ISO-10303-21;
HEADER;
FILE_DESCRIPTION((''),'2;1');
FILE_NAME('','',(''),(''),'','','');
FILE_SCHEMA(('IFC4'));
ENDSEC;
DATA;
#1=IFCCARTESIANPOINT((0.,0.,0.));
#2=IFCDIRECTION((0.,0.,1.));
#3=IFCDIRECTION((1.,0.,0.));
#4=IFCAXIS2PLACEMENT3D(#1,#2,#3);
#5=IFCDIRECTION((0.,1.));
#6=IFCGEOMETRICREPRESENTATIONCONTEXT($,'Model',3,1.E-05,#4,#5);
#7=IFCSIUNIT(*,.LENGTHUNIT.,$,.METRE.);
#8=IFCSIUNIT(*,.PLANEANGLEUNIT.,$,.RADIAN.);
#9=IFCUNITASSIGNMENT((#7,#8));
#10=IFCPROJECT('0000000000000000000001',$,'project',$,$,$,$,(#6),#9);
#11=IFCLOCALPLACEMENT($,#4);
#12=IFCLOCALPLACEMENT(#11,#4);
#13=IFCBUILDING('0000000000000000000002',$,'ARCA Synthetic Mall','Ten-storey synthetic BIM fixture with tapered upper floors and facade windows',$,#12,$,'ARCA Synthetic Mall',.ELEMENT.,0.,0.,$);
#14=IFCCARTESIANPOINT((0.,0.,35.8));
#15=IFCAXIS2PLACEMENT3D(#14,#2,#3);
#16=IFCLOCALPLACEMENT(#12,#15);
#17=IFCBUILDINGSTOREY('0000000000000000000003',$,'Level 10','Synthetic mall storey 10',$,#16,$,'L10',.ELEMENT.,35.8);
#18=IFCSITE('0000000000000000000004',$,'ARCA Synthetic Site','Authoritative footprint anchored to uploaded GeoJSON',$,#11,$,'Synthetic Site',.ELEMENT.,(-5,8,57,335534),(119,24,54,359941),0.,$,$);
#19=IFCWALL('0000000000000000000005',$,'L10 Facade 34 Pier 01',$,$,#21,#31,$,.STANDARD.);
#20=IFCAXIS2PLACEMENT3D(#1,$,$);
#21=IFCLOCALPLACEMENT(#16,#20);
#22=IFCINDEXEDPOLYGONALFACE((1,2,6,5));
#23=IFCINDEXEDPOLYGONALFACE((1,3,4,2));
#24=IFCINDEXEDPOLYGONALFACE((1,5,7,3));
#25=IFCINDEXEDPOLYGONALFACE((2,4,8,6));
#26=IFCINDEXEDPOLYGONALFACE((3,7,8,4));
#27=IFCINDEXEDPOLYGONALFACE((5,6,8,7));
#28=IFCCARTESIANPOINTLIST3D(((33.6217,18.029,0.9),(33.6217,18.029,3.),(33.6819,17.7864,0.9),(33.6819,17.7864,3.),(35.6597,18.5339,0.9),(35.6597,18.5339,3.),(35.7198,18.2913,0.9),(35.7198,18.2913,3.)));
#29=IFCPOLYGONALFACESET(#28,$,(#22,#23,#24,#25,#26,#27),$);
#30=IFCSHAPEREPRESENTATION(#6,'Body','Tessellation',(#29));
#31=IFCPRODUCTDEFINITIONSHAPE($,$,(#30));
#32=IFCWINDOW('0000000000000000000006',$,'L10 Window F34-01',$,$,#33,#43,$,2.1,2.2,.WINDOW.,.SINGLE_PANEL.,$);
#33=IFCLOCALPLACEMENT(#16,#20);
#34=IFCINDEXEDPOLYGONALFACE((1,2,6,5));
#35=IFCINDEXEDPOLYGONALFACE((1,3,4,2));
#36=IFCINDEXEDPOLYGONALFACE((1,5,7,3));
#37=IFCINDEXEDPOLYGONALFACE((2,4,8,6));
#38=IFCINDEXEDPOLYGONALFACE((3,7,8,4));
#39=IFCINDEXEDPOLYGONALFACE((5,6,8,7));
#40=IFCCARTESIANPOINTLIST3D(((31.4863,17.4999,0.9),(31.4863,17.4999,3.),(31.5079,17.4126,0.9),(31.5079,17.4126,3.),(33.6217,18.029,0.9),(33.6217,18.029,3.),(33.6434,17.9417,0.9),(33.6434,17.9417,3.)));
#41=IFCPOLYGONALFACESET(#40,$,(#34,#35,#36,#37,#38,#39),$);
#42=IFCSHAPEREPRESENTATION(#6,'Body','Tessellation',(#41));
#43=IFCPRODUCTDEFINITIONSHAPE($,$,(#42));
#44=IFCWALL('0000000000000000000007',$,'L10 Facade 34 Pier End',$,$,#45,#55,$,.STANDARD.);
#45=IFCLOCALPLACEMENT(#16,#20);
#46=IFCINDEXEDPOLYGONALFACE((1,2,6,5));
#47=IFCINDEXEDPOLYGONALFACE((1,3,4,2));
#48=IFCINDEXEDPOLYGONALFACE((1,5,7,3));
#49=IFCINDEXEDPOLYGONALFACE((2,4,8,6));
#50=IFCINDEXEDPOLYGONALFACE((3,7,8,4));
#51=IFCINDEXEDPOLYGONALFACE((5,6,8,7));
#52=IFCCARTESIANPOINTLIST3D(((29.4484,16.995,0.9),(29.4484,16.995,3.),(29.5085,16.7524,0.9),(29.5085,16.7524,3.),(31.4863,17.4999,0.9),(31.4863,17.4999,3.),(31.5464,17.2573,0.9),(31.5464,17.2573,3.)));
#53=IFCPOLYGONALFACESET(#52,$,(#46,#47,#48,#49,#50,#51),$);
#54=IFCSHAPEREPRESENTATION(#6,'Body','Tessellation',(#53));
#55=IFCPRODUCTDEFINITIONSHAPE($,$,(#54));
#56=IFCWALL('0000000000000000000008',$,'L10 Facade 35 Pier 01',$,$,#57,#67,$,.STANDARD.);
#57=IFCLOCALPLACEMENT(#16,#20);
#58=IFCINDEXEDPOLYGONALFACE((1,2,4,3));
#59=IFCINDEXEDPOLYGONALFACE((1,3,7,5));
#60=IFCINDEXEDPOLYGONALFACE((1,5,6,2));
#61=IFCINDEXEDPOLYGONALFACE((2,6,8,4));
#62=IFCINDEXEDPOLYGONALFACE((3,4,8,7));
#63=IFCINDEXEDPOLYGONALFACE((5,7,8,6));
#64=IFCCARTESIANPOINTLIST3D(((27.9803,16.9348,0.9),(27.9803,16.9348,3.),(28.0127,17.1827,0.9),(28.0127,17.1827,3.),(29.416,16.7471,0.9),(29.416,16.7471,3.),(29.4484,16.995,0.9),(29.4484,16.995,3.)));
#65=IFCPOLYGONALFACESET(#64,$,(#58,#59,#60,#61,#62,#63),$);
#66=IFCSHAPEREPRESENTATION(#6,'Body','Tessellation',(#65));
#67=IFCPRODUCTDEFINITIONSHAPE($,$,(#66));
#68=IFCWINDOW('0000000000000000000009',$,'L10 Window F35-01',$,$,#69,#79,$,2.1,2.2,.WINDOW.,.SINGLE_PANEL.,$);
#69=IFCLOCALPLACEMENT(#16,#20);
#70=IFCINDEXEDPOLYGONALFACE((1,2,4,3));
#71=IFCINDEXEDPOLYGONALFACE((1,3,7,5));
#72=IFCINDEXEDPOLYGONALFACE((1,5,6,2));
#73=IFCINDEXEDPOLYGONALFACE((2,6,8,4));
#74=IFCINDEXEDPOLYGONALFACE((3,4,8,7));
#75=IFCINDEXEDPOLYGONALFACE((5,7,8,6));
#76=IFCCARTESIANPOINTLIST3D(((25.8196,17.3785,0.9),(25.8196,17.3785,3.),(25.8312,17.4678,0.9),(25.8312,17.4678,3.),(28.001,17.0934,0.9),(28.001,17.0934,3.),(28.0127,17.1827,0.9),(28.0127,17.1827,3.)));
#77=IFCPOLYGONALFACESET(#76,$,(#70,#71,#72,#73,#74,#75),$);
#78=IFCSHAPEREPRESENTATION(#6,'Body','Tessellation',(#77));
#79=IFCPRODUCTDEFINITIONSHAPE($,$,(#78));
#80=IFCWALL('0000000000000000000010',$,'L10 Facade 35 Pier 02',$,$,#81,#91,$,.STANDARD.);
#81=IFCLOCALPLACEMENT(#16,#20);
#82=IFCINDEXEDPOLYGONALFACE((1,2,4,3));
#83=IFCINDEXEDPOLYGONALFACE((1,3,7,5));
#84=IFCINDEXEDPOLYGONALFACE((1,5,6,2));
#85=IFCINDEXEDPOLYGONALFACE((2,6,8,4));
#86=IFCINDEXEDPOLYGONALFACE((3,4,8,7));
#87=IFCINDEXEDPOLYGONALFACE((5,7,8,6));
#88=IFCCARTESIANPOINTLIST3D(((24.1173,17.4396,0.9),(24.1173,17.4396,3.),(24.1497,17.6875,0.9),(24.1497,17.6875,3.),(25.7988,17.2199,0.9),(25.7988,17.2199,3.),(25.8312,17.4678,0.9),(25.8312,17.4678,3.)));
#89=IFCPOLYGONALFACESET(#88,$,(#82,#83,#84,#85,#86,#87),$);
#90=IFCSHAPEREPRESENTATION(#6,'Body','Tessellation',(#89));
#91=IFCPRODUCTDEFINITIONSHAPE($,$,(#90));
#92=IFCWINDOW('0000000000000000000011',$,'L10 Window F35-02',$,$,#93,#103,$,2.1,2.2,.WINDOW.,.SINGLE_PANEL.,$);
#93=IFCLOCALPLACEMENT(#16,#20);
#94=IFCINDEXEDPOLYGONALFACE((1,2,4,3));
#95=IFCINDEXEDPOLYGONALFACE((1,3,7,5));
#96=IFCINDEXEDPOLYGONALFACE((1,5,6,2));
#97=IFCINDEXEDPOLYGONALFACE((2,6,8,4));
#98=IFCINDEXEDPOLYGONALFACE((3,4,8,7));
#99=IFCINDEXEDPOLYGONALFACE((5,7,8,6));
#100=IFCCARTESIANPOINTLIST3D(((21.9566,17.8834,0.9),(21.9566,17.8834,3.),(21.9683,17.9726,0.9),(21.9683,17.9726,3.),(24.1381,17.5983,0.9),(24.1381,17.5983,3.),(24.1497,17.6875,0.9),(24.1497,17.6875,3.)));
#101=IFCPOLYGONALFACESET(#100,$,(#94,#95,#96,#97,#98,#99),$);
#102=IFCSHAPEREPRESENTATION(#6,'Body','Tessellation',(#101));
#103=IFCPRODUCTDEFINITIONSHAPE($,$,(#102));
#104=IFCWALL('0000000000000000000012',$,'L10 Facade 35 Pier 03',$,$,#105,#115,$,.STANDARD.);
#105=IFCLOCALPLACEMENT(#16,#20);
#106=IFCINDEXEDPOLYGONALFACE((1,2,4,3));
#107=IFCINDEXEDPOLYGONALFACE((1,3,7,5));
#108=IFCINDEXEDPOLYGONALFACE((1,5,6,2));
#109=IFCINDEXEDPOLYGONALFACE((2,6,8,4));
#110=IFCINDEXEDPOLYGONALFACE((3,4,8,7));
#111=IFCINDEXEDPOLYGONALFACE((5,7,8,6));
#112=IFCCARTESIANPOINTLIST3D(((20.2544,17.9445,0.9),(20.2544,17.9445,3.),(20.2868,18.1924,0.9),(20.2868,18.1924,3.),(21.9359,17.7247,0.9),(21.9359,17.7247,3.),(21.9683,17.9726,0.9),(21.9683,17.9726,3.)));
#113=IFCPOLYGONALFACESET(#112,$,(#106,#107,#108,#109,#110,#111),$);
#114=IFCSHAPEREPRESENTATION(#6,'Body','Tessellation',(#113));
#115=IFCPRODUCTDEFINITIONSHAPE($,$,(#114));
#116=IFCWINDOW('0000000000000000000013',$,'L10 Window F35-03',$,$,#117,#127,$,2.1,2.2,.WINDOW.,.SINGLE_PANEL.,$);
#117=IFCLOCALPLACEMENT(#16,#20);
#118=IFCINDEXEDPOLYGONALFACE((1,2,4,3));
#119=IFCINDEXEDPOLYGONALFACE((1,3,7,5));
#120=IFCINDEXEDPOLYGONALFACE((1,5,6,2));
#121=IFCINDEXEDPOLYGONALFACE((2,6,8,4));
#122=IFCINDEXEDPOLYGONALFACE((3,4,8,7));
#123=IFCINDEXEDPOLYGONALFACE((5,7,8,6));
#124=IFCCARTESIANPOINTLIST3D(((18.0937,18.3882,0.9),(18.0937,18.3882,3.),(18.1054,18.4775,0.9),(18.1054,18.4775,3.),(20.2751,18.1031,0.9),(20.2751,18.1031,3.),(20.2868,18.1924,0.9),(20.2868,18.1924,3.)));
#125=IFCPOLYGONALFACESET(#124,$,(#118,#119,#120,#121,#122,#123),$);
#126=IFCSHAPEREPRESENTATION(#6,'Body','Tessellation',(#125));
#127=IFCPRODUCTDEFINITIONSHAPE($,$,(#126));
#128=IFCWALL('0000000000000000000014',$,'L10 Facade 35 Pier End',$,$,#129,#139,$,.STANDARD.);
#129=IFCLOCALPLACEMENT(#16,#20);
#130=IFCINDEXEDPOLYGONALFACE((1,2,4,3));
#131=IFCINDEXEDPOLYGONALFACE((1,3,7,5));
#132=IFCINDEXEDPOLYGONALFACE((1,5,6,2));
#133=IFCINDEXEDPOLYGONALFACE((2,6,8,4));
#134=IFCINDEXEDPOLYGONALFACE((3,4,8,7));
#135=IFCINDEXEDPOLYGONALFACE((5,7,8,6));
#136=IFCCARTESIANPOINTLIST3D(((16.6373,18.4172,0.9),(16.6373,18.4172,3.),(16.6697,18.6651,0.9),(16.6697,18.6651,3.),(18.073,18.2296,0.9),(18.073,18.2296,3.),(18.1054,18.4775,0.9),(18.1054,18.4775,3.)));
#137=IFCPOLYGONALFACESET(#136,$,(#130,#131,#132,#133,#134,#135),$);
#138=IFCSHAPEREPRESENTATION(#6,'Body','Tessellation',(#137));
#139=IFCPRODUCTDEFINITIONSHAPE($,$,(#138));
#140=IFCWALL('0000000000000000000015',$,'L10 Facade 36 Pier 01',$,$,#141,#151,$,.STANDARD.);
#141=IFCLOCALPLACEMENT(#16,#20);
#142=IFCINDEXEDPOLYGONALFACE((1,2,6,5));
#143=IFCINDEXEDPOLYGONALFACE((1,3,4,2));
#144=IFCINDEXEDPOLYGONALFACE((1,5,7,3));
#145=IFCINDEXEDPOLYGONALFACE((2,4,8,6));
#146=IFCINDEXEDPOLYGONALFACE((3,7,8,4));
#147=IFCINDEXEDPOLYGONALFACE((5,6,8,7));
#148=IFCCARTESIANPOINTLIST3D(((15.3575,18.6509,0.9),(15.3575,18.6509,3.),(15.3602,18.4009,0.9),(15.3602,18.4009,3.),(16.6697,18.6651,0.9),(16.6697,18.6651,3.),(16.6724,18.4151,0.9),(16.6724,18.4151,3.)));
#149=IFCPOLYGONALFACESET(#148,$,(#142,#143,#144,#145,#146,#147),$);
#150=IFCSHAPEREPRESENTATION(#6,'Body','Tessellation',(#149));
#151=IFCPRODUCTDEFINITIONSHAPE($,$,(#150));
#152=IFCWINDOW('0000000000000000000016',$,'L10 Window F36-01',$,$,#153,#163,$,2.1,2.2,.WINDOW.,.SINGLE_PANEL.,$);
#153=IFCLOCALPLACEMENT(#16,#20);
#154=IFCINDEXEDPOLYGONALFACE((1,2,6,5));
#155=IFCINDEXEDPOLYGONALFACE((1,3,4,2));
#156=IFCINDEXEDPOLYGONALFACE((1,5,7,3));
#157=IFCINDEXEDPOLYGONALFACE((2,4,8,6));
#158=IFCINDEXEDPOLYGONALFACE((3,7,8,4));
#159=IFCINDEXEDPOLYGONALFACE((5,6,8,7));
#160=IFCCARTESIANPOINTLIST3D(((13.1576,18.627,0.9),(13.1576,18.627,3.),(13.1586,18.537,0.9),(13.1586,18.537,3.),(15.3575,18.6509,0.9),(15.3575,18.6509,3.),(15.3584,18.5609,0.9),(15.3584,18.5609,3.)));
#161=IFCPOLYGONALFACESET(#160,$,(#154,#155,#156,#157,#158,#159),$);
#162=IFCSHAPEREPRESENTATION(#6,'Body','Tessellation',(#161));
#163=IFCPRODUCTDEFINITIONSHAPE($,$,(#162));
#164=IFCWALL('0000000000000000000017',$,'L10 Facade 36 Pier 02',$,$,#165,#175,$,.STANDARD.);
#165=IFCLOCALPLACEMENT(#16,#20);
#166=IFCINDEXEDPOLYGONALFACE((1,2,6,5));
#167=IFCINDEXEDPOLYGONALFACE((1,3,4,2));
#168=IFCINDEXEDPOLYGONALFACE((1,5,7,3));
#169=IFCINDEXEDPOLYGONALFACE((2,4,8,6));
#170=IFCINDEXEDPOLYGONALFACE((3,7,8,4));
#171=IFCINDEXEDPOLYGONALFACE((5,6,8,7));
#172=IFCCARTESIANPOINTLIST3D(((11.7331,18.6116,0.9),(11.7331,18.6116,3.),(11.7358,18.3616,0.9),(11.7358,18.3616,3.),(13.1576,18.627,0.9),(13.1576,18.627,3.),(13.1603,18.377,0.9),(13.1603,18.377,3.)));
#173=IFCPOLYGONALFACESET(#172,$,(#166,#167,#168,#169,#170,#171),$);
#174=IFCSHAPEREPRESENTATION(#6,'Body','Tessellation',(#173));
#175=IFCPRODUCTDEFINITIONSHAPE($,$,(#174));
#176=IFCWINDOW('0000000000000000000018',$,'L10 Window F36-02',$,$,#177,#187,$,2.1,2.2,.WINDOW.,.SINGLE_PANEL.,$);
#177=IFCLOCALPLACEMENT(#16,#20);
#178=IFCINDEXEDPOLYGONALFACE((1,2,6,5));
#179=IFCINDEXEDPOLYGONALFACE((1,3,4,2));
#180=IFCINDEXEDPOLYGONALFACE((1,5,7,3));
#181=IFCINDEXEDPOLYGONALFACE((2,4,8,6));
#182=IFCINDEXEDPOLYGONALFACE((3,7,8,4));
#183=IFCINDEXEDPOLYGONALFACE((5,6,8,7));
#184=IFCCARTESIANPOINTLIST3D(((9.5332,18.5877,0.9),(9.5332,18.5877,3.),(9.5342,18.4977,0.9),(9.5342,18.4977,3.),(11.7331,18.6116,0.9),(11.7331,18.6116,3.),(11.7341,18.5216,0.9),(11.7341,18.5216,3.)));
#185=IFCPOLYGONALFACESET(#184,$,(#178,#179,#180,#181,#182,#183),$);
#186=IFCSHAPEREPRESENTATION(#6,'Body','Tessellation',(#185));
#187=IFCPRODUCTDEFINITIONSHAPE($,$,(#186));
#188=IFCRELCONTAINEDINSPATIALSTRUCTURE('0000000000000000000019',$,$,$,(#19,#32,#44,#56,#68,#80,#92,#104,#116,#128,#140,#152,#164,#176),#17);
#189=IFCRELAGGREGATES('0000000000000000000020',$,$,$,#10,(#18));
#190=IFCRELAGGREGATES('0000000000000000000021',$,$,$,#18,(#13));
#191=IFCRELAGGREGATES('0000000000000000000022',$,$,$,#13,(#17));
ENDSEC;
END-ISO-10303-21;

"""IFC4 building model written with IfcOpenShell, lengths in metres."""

from ifc_helpers import new_model, si_unit, direction, frame, origin_with_axes, place, context, project, spatial, polyline, outline, extrude, element, save


model = new_model("IFC4")

# Units and contexts
model_context = context("Model", 3, precision=1e-05, world=origin_with_axes(), true_north=direction((0.0, 1.0)))
ifc_project = project(units=[si_unit("LENGTHUNIT", "METRE"), si_unit("PLANEANGLEUNIT", "RADIAN")], contexts=[model_context])

# Site, building, storey
site_placement = place(None, origin_with_axes())
site = spatial("IfcSite", under=ifc_project, at=site_placement, Name="ARCA Synthetic Site", Description="Authoritative footprint anchored to uploaded GeoJSON", LongName="Synthetic Site", CompositionType="ELEMENT", RefLatitude=(-5, 8, 57, 335534), RefLongitude=(119, 24, 54, 359941), RefElevation=0.0)
building_placement = place(site_placement, origin_with_axes())
building = spatial("IfcBuilding", under=site, at=building_placement, Name="ARCA Synthetic Mall", Description="Ten-storey synthetic BIM fixture with tapered upper floors and facade windows", LongName="ARCA Synthetic Mall", CompositionType="ELEMENT", ElevationOfRefHeight=0.0, ElevationOfTerrain=0.0)
storey_placement = place(building_placement, frame((0.0, 0.0, 35.8), z_axis=(0.0, 0.0, 1.0), x_axis=(1.0, 0.0, 0.0)))
storey = spatial("IfcBuildingStorey", under=building, at=storey_placement, Name="Level 10", Description="Synthetic mall storey 10", LongName="L10", CompositionType="ELEMENT", Elevation=35.8)

# Wall
wall_1_placement = place(storey_placement, frame((0.0, 0.0, 0.9), z_axis=(0.0, 0.0, 1.0), x_axis=(1.0, 0.0, 0.0)))
element("IfcWall", 1, at=wall_1_placement, inside=storey, Name="L10 Facade 34 Pier 01", PredefinedType="STANDARD", context=model_context, shape_type="SweptSolid", body=[
    extrude(outline(polyline([(35.6597, 18.5339), (33.6217, 18.029), (33.6819, 17.7864), (35.7198, 18.2913), (35.6597, 18.5339)])), origin_with_axes(), (0.0, 0.0, 1.0), 2.1),
])

# Window
window_1_placement = place(storey_placement, frame((0.0, 0.0, 0.9), z_axis=(0.0, 0.0, 1.0), x_axis=(1.0, 0.0, 0.0)))
element("IfcWindow", 2, at=window_1_placement, inside=storey, Name="L10 Window F34-01", OverallHeight=2.1, OverallWidth=2.2, PartitioningType="SINGLE_PANEL", PredefinedType="WINDOW", context=model_context, shape_type="SweptSolid", body=[
    extrude(outline(polyline([(33.6217, 18.029), (31.4863, 17.4999), (31.5079, 17.4126), (33.6434, 17.9417), (33.6217, 18.029)])), origin_with_axes(), (0.0, 0.0, 1.0), 2.1),
])

# Walls
wall_2_placement = place(storey_placement, frame((0.0, 0.0, 0.9), z_axis=(0.0, 0.0, 1.0), x_axis=(1.0, 0.0, 0.0)))
element("IfcWall", 3, at=wall_2_placement, inside=storey, Name="L10 Facade 34 Pier End", PredefinedType="STANDARD", context=model_context, shape_type="SweptSolid", body=[
    extrude(outline(polyline([(31.4863, 17.4999), (29.4484, 16.995), (29.5085, 16.7524), (31.5464, 17.2573), (31.4863, 17.4999)])), origin_with_axes(), (0.0, 0.0, 1.0), 2.1),
])
wall_3_placement = place(storey_placement, frame((0.0, 0.0, 0.9), z_axis=(0.0, 0.0, 1.0), x_axis=(1.0, 0.0, 0.0)))
element("IfcWall", 4, at=wall_3_placement, inside=storey, Name="L10 Facade 35 Pier 01", PredefinedType="STANDARD", context=model_context, shape_type="SweptSolid", body=[
    extrude(outline(polyline([(29.4484, 16.995), (28.0127, 17.1827), (27.9803, 16.9348), (29.416, 16.7471), (29.4484, 16.995)])), origin_with_axes(), (0.0, 0.0, 1.0), 2.1),
])

# Window
window_2_placement = place(storey_placement, frame((0.0, 0.0, 0.9), z_axis=(0.0, 0.0, 1.0), x_axis=(1.0, 0.0, 0.0)))
element("IfcWindow", 5, at=window_2_placement, inside=storey, Name="L10 Window F35-01", OverallHeight=2.1, OverallWidth=2.2, PartitioningType="SINGLE_PANEL", PredefinedType="WINDOW", context=model_context, shape_type="SweptSolid", body=[
    extrude(outline(polyline([(28.0127, 17.1827), (25.8312, 17.4678), (25.8196, 17.3785), (28.001, 17.0934), (28.0127, 17.1827)])), origin_with_axes(), (0.0, 0.0, 1.0), 2.1),
])

# Wall
wall_4_placement = place(storey_placement, frame((0.0, 0.0, 0.9), z_axis=(0.0, 0.0, 1.0), x_axis=(1.0, 0.0, 0.0)))
element("IfcWall", 6, at=wall_4_placement, inside=storey, Name="L10 Facade 35 Pier 02", PredefinedType="STANDARD", context=model_context, shape_type="SweptSolid", body=[
    extrude(outline(polyline([(25.8312, 17.4678), (24.1497, 17.6875), (24.1173, 17.4396), (25.7988, 17.2199), (25.8312, 17.4678)])), origin_with_axes(), (0.0, 0.0, 1.0), 2.1),
])

# Window
window_3_placement = place(storey_placement, frame((0.0, 0.0, 0.9), z_axis=(0.0, 0.0, 1.0), x_axis=(1.0, 0.0, 0.0)))
element("IfcWindow", 7, at=window_3_placement, inside=storey, Name="L10 Window F35-02", OverallHeight=2.1, OverallWidth=2.2, PartitioningType="SINGLE_PANEL", PredefinedType="WINDOW", context=model_context, shape_type="SweptSolid", body=[
    extrude(outline(polyline([(24.1497, 17.6875), (21.9683, 17.9726), (21.9566, 17.8834), (24.1381, 17.5983), (24.1497, 17.6875)])), origin_with_axes(), (0.0, 0.0, 1.0), 2.1),
])

# Wall
wall_5_placement = place(storey_placement, frame((0.0, 0.0, 0.9), z_axis=(0.0, 0.0, 1.0), x_axis=(1.0, 0.0, 0.0)))
element("IfcWall", 8, at=wall_5_placement, inside=storey, Name="L10 Facade 35 Pier 03", PredefinedType="STANDARD", context=model_context, shape_type="SweptSolid", body=[
    extrude(outline(polyline([(21.9683, 17.9726), (20.2868, 18.1924), (20.2544, 17.9445), (21.9359, 17.7247), (21.9683, 17.9726)])), origin_with_axes(), (0.0, 0.0, 1.0), 2.1),
])

# Window
window_4_placement = place(storey_placement, frame((0.0, 0.0, 0.9), z_axis=(0.0, 0.0, 1.0), x_axis=(1.0, 0.0, 0.0)))
element("IfcWindow", 9, at=window_4_placement, inside=storey, Name="L10 Window F35-03", OverallHeight=2.1, OverallWidth=2.2, PartitioningType="SINGLE_PANEL", PredefinedType="WINDOW", context=model_context, shape_type="SweptSolid", body=[
    extrude(outline(polyline([(20.2868, 18.1924), (18.1054, 18.4775), (18.0937, 18.3882), (20.2751, 18.1031), (20.2868, 18.1924)])), origin_with_axes(), (0.0, 0.0, 1.0), 2.1),
])

# Walls
wall_6_placement = place(storey_placement, frame((0.0, 0.0, 0.9), z_axis=(0.0, 0.0, 1.0), x_axis=(1.0, 0.0, 0.0)))
element("IfcWall", 10, at=wall_6_placement, inside=storey, Name="L10 Facade 35 Pier End", PredefinedType="STANDARD", context=model_context, shape_type="SweptSolid", body=[
    extrude(outline(polyline([(18.1054, 18.4775), (16.6697, 18.6651), (16.6373, 18.4172), (18.073, 18.2296), (18.1054, 18.4775)])), origin_with_axes(), (0.0, 0.0, 1.0), 2.1),
])
wall_7_placement = place(storey_placement, frame((0.0, 0.0, 0.9), z_axis=(0.0, 0.0, 1.0), x_axis=(1.0, 0.0, 0.0)))
element("IfcWall", 11, at=wall_7_placement, inside=storey, Name="L10 Facade 36 Pier 01", PredefinedType="STANDARD", context=model_context, shape_type="SweptSolid", body=[
    extrude(outline(polyline([(16.6697, 18.6651), (15.3575, 18.6509), (15.3602, 18.4009), (16.6724, 18.4151), (16.6697, 18.6651)])), origin_with_axes(), (0.0, 0.0, 1.0), 2.1),
])

# Window
window_5_placement = place(storey_placement, frame((0.0, 0.0, 0.9), z_axis=(0.0, 0.0, 1.0), x_axis=(1.0, 0.0, 0.0)))
element("IfcWindow", 12, at=window_5_placement, inside=storey, Name="L10 Window F36-01", OverallHeight=2.1, OverallWidth=2.2, PartitioningType="SINGLE_PANEL", PredefinedType="WINDOW", context=model_context, shape_type="SweptSolid", body=[
    extrude(outline(polyline([(15.3575, 18.6509), (13.1576, 18.627), (13.1586, 18.537), (15.3584, 18.5609), (15.3575, 18.6509)])), origin_with_axes(), (0.0, 0.0, 1.0), 2.1),
])

# Wall
wall_8_placement = place(storey_placement, frame((0.0, 0.0, 0.9), z_axis=(0.0, 0.0, 1.0), x_axis=(1.0, 0.0, 0.0)))
element("IfcWall", 13, at=wall_8_placement, inside=storey, Name="L10 Facade 36 Pier 02", PredefinedType="STANDARD", context=model_context, shape_type="SweptSolid", body=[
    extrude(outline(polyline([(13.1576, 18.627), (11.7331, 18.6116), (11.7358, 18.3616), (13.1603, 18.377), (13.1576, 18.627)])), origin_with_axes(), (0.0, 0.0, 1.0), 2.1),
])

# Window
window_6_placement = place(storey_placement, frame((0.0, 0.0, 0.9), z_axis=(0.0, 0.0, 1.0), x_axis=(1.0, 0.0, 0.0)))
element("IfcWindow", 14, at=window_6_placement, inside=storey, Name="L10 Window F36-02", OverallHeight=2.1, OverallWidth=2.2, PartitioningType="SINGLE_PANEL", PredefinedType="WINDOW", context=model_context, shape_type="SweptSolid", body=[
    extrude(outline(polyline([(11.7331, 18.6116), (9.5332, 18.5877), (9.5342, 18.4977), (11.7341, 18.5216), (11.7331, 18.6116)])), origin_with_axes(), (0.0, 0.0, 1.0), 2.1),
])

save(model, "model.ifc")
